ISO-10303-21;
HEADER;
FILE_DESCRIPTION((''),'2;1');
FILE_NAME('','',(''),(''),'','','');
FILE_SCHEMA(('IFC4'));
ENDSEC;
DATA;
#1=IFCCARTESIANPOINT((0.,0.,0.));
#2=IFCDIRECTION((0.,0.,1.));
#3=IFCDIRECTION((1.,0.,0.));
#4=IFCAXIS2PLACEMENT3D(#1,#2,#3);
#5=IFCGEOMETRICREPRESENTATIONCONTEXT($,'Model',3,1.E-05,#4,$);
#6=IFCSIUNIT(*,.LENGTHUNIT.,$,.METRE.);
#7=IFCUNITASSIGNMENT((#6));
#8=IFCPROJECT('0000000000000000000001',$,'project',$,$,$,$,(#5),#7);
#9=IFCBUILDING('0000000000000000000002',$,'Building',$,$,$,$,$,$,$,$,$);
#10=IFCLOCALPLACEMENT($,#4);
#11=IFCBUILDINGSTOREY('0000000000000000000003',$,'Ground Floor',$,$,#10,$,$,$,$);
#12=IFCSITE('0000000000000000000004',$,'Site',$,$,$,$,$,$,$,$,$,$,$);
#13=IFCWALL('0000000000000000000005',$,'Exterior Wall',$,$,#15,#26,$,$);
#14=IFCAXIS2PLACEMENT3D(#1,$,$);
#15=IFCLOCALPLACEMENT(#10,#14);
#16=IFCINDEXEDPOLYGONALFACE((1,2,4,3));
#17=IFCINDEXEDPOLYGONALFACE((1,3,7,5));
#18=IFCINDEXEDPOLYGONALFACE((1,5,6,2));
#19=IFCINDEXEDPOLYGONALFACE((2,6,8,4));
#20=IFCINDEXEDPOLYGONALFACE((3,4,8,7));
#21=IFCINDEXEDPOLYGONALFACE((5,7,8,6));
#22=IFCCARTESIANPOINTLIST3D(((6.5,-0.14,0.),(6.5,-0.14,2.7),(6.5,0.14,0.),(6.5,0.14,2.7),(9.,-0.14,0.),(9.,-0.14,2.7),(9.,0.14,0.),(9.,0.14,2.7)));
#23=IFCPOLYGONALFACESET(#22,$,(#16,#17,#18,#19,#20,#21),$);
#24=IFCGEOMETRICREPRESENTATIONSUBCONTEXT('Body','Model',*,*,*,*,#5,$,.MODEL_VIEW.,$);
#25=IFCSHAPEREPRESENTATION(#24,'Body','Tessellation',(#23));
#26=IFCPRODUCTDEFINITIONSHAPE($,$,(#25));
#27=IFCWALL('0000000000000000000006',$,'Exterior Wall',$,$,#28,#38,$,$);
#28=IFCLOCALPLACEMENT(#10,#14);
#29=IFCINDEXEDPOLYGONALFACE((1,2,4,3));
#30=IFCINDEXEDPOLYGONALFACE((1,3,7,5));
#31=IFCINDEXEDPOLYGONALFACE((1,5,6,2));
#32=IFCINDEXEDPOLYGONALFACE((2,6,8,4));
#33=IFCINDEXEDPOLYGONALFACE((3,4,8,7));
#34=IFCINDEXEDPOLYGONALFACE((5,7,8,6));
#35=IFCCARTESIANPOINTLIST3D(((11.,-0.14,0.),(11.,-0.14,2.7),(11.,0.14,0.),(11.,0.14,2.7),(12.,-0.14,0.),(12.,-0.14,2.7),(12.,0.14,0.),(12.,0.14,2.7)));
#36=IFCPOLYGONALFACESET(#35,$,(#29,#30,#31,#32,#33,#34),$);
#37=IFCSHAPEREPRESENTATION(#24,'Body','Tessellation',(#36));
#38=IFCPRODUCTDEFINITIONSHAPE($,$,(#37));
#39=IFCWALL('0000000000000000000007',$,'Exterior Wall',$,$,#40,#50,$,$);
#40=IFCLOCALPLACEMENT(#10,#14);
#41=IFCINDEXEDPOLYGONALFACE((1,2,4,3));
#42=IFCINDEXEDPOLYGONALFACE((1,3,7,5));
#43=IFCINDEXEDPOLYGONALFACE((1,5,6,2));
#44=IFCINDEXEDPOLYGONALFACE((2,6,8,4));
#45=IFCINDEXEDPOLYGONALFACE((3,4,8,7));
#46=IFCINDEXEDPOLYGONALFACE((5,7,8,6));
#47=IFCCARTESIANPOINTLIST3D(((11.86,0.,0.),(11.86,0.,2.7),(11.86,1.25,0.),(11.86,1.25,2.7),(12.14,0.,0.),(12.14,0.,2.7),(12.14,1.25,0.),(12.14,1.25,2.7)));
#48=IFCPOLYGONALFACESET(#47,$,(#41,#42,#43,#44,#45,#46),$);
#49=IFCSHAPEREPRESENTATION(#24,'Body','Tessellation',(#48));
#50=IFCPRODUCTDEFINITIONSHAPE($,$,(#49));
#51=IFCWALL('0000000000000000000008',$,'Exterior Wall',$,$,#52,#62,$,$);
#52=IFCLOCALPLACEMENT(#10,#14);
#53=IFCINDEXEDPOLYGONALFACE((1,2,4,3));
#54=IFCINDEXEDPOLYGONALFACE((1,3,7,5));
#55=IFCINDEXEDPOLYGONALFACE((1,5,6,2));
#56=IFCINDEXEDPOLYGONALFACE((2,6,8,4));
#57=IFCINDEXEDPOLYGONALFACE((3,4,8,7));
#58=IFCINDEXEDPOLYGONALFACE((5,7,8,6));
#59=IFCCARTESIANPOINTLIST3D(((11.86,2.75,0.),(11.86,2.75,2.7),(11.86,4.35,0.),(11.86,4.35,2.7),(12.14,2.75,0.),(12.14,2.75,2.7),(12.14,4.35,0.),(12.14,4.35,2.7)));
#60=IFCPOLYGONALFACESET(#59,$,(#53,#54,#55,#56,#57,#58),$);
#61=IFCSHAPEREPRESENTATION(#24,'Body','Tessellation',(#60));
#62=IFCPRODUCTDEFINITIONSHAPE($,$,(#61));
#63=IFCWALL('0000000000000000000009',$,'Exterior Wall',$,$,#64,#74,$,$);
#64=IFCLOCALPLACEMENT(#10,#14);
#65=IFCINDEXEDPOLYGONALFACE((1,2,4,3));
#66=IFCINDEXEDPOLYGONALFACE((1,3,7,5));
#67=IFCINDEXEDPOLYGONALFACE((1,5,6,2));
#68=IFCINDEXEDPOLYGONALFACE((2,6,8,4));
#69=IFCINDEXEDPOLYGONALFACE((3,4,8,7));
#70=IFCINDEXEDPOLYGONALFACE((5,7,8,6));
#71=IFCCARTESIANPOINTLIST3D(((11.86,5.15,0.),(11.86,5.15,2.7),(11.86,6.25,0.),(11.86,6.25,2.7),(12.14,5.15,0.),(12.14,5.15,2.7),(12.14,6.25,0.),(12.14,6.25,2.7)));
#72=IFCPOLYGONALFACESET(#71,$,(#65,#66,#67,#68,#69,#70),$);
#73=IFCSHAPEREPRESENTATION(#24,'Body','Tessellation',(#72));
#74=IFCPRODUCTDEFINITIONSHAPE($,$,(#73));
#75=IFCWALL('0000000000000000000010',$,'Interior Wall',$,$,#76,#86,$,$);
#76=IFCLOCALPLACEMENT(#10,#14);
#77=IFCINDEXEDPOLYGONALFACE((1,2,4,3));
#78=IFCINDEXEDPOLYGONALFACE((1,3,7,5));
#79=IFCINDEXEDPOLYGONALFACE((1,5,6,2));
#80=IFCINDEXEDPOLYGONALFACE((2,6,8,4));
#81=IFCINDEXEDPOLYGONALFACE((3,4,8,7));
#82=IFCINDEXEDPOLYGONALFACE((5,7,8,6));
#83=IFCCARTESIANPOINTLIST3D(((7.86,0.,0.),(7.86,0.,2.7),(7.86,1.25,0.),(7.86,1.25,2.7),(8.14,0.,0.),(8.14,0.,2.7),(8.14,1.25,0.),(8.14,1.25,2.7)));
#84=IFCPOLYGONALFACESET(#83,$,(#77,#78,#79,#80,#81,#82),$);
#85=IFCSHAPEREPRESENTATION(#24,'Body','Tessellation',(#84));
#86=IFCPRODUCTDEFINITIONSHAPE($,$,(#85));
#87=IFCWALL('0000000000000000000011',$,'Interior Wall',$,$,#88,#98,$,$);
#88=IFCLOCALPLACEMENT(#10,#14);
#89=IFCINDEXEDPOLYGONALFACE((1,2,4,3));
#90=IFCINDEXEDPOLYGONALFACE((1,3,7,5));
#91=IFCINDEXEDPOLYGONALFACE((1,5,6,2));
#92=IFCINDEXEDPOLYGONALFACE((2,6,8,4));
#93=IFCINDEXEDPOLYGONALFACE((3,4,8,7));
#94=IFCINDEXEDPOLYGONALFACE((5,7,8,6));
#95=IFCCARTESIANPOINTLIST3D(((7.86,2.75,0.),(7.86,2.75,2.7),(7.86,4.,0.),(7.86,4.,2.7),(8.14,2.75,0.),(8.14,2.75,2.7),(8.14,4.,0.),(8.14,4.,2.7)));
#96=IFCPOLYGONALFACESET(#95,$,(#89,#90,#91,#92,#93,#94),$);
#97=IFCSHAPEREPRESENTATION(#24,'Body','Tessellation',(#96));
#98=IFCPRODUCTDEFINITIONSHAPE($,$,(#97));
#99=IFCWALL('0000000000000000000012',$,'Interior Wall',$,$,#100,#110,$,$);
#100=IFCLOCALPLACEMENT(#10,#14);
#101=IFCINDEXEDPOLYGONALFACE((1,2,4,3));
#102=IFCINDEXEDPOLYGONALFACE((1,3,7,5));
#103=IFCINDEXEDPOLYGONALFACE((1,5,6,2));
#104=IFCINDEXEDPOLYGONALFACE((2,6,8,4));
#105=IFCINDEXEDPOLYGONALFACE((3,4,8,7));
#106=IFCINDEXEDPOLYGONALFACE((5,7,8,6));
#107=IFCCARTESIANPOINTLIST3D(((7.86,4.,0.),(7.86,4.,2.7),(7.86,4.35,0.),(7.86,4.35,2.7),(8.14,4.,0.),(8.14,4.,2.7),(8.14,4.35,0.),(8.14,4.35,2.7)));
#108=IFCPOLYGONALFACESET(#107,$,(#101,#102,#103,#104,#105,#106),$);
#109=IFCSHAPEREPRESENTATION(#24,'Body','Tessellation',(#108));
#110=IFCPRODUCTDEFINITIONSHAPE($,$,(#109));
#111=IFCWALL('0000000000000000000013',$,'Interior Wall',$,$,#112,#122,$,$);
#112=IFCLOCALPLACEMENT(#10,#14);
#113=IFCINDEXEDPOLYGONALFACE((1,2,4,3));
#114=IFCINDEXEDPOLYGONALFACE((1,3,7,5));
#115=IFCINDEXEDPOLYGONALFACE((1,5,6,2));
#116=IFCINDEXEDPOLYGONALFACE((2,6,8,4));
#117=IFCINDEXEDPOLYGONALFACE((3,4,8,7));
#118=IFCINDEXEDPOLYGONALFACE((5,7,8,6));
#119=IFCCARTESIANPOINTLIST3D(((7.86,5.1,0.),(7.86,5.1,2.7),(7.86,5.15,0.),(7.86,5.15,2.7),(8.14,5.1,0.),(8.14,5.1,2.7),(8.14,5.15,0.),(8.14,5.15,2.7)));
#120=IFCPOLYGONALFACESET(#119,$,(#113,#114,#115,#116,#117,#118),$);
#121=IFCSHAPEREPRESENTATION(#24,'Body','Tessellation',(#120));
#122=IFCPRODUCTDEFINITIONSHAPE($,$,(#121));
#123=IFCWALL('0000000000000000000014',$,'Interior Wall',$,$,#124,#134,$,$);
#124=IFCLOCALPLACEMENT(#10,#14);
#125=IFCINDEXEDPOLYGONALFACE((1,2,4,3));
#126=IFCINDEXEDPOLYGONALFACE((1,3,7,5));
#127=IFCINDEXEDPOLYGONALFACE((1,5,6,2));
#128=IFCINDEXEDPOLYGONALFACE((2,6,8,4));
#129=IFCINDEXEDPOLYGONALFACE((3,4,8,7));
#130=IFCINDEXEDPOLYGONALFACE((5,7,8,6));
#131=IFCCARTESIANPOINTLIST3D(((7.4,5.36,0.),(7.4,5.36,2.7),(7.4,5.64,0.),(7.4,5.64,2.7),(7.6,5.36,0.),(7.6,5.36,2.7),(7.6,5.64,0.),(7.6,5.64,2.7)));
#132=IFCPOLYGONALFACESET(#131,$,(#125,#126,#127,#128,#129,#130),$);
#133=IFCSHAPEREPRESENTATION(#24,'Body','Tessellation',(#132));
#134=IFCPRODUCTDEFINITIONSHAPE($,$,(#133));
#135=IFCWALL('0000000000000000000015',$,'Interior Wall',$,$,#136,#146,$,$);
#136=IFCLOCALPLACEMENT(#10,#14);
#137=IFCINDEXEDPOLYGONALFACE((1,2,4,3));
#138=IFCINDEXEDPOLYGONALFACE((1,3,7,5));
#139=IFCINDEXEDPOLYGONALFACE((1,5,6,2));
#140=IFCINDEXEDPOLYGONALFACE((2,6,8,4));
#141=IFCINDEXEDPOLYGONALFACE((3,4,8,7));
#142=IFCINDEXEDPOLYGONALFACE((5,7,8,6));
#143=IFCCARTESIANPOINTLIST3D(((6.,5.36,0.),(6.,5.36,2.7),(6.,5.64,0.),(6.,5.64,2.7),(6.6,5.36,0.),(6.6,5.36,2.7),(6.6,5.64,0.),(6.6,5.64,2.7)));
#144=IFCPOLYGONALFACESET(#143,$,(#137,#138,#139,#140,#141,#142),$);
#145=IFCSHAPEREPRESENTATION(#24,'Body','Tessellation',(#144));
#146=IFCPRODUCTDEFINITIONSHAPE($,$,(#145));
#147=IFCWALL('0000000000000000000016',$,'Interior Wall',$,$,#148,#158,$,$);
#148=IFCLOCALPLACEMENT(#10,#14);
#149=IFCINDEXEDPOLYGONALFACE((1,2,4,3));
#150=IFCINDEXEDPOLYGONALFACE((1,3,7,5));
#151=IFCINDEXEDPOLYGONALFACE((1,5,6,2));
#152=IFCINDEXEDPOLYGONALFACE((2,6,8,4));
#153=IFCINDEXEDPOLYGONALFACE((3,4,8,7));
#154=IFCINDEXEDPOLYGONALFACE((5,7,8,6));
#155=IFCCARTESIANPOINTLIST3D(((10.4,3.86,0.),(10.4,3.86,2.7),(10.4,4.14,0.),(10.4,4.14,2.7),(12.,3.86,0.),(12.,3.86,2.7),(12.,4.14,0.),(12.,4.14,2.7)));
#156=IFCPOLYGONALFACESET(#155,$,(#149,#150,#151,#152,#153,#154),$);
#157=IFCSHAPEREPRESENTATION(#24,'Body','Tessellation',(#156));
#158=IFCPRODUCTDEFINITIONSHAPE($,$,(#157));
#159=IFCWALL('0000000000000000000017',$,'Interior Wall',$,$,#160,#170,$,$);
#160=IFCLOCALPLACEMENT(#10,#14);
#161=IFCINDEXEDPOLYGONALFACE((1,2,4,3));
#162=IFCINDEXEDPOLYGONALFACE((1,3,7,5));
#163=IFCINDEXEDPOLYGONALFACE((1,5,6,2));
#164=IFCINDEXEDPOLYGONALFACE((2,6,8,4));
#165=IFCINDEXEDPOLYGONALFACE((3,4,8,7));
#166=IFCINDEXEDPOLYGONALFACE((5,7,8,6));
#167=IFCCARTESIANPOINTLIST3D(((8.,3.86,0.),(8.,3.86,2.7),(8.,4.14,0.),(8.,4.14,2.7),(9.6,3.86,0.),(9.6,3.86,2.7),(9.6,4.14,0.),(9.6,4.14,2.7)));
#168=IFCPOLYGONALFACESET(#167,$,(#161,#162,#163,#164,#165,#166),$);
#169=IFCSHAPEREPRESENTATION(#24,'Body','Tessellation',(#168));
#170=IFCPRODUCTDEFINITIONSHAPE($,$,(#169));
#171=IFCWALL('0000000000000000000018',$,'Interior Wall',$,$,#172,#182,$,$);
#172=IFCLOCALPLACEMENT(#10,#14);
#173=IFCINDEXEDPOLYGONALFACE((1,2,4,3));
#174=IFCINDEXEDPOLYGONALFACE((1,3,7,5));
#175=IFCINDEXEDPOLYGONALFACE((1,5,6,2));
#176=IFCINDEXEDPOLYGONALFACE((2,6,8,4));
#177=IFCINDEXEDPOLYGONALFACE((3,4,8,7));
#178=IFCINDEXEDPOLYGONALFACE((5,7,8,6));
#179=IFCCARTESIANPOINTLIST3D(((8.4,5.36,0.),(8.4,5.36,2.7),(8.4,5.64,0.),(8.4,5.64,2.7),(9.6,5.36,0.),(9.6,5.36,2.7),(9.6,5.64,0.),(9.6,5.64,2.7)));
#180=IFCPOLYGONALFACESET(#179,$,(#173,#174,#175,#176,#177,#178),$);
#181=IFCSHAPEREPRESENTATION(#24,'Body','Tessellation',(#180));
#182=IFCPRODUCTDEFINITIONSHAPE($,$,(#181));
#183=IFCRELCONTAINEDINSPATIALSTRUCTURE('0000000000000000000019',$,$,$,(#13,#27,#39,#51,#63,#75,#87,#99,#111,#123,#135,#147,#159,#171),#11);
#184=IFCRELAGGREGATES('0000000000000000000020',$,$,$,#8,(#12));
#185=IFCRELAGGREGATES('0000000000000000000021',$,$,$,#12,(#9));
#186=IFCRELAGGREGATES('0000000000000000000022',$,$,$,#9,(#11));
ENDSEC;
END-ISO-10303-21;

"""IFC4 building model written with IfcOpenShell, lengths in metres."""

from ifc_helpers import new_model, si_unit, frame, origin_with_axes, place, context, subcontext, project, spatial, indexed_curve, outline, extrude, element, save


model = new_model("IFC4")

# Units and contexts
model_context = context("Model", 3, precision=1e-05, world=origin_with_axes())
body_context = subcontext(model_context, "Body", "Model", "MODEL_VIEW")
ifc_project = project(units=[si_unit("LENGTHUNIT", "METRE")], contexts=[model_context])

# Site, building, storey
site = spatial("IfcSite", under=ifc_project, Name="Site")
building = spatial("IfcBuilding", under=site, Name="Building")
storey_placement = place(None, origin_with_axes())
storey = spatial("IfcBuildingStorey", under=building, at=storey_placement, Name="Ground Floor")

# Walls
wall_1_placement = place(storey_placement, frame((6.5, 0.0, 0.0), z_axis=(0.0, 0.0, 1.0), x_axis=(1.0, 0.0, 0.0)))
element("IfcWall", 1, at=wall_1_placement, inside=storey, Name="Exterior Wall", context=body_context, shape_type="SweptSolid", body=[
    extrude(outline(indexed_curve([(0.0, 0.0), (0.0, 0.28), (2.5, 0.28), (2.5, 0.0), (0.0, 0.0)], self_intersect=False)), frame((0.0, -0.14, 0.0), z_axis=(0.0, 0.0, 1.0), x_axis=(1.0, 0.0, 0.0)), (0.0, 0.0, 1.0), 2.7),
])
wall_2_placement = place(storey_placement, frame((11.0, 0.0, 0.0), z_axis=(0.0, 0.0, 1.0), x_axis=(1.0, 0.0, 0.0)))
element("IfcWall", 2, at=wall_2_placement, inside=storey, Name="Exterior Wall", context=body_context, shape_type="SweptSolid", body=[
    extrude(outline(indexed_curve([(0.0, 0.0), (0.0, 0.28), (1.0, 0.28), (1.0, 0.0), (0.0, 0.0)], self_intersect=False)), frame((0.0, -0.14, 0.0), z_axis=(0.0, 0.0, 1.0), x_axis=(1.0, 0.0, 0.0)), (0.0, 0.0, 1.0), 2.7),
])
wall_3_placement = place(storey_placement, frame((12.0, 0.0, 0.0), z_axis=(0.0, 0.0, 1.0), x_axis=(0.0, 1.0, 0.0)))
element("IfcWall", 3, at=wall_3_placement, inside=storey, Name="Exterior Wall", context=body_context, shape_type="SweptSolid", body=[
    extrude(outline(indexed_curve([(0.0, 0.0), (0.0, 0.28), (1.25, 0.28), (1.25, 0.0), (0.0, 0.0)], self_intersect=False)), frame((0.0, -0.14, 0.0), z_axis=(0.0, 0.0, 1.0), x_axis=(1.0, 0.0, 0.0)), (0.0, 0.0, 1.0), 2.7),
])
wall_4_placement = place(storey_placement, frame((12.0, 2.75, 0.0), z_axis=(0.0, 0.0, 1.0), x_axis=(0.0, 1.0, 0.0)))
element("IfcWall", 4, at=wall_4_placement, inside=storey, Name="Exterior Wall", context=body_context, shape_type="SweptSolid", body=[
    extrude(outline(indexed_curve([(0.0, 0.0), (0.0, 0.28), (1.6, 0.28), (1.6, 0.0), (0.0, 0.0)], self_intersect=False)), frame((0.0, -0.14, 0.0), z_axis=(0.0, 0.0, 1.0), x_axis=(1.0, 0.0, 0.0)), (0.0, 0.0, 1.0), 2.7),
])
wall_5_placement = place(storey_placement, frame((12.0, 5.15, 0.0), z_axis=(0.0, 0.0, 1.0), x_axis=(0.0, 1.0, 0.0)))
element("IfcWall", 5, at=wall_5_placement, inside=storey, Name="Exterior Wall", context=body_context, shape_type="SweptSolid", body=[
    extrude(outline(indexed_curve([(0.0, 0.0), (0.0, 0.28), (1.1, 0.28), (1.1, 0.0), (0.0, 0.0)], self_intersect=False)), frame((0.0, -0.14, 0.0), z_axis=(0.0, 0.0, 1.0), x_axis=(1.0, 0.0, 0.0)), (0.0, 0.0, 1.0), 2.7),
])
for number, where, z_axis, x_axis, name in (
    (6, (8.0, 0.0, 0.0), (0.0, 0.0, 1.0), (0.0, 1.0, 0.0), "Interior Wall"),
    (7, (8.0, 2.75, 0.0), (0.0, 0.0, 1.0), (0.0, 1.0, 0.0), "Interior Wall"),
):
    element("IfcWall", number, at=place(storey_placement, frame(where, z_axis=z_axis, x_axis=x_axis)), inside=storey, Name=name, context=body_context, shape_type="SweptSolid", body=[
        extrude(outline(indexed_curve([(0.0, 0.0), (0.0, 0.28), (1.25, 0.28), (1.25, 0.0), (0.0, 0.0)], self_intersect=False)), frame((0.0, -0.14, 0.0), z_axis=(0.0, 0.0, 1.0), x_axis=(1.0, 0.0, 0.0)), (0.0, 0.0, 1.0), 2.7),
    ])
wall_6_placement = place(storey_placement, frame((8.0, 4.0, 0.0), z_axis=(0.0, 0.0, 1.0), x_axis=(0.0, 1.0, 0.0)))
element("IfcWall", 8, at=wall_6_placement, inside=storey, Name="Interior Wall", context=body_context, shape_type="SweptSolid", body=[
    extrude(outline(indexed_curve([(0.0, 0.0), (0.0, 0.28), (0.35, 0.28), (0.35, 0.0), (0.0, 0.0)], self_intersect=False)), frame((0.0, -0.14, 0.0), z_axis=(0.0, 0.0, 1.0), x_axis=(1.0, 0.0, 0.0)), (0.0, 0.0, 1.0), 2.7),
])
wall_7_placement = place(storey_placement, frame((8.0, 5.15, 0.0), z_axis=(0.0, 0.0, 1.0), x_axis=(0.0, -1.0, 0.0)))
element("IfcWall", 9, at=wall_7_placement, inside=storey, Name="Interior Wall", context=body_context, shape_type="SweptSolid", body=[
    extrude(outline(indexed_curve([(0.0, 0.0), (0.0, 0.28), (0.05, 0.28), (0.05, 0.0), (0.0, 0.0)], self_intersect=False)), frame((0.0, -0.14, 0.0), z_axis=(0.0, 0.0, 1.0), x_axis=(1.0, 0.0, 0.0)), (0.0, 0.0, 1.0), 2.7),
])
wall_8_placement = place(storey_placement, frame((7.6, 5.5, 0.0), z_axis=(0.0, 0.0, 1.0), x_axis=(-1.0, 0.0, 0.0)))
element("IfcWall", 10, at=wall_8_placement, inside=storey, Name="Interior Wall", context=body_context, shape_type="SweptSolid", body=[
    extrude(outline(indexed_curve([(0.0, 0.0), (0.0, 0.28), (0.2, 0.28), (0.2, 0.0), (0.0, 0.0)], self_intersect=False)), frame((0.0, -0.14, 0.0), z_axis=(0.0, 0.0, 1.0), x_axis=(1.0, 0.0, 0.0)), (0.0, 0.0, 1.0), 2.7),
])
wall_9_placement = place(storey_placement, frame((6.6, 5.5, 0.0), z_axis=(0.0, 0.0, 1.0), x_axis=(-1.0, 0.0, 0.0)))
element("IfcWall", 11, at=wall_9_placement, inside=storey, Name="Interior Wall", context=body_context, shape_type="SweptSolid", body=[
    extrude(outline(indexed_curve([(0.0, 0.0), (0.0, 0.28), (0.6, 0.28), (0.6, 0.0), (0.0, 0.0)], self_intersect=False)), frame((0.0, -0.14, 0.0), z_axis=(0.0, 0.0, 1.0), x_axis=(1.0, 0.0, 0.0)), (0.0, 0.0, 1.0), 2.7),
])
for number, where, z_axis, x_axis, name in (
    (12, (12.0, 4.0, 0.0), (0.0, 0.0, 1.0), (-1.0, 0.0, 0.0), "Interior Wall"),
    (13, (9.6, 4.0, 0.0), (0.0, 0.0, 1.0), (-1.0, 0.0, 0.0), "Interior Wall"),
):
    element("IfcWall", number, at=place(storey_placement, frame(where, z_axis=z_axis, x_axis=x_axis)), inside=storey, Name=name, context=body_context, shape_type="SweptSolid", body=[
        extrude(outline(indexed_curve([(0.0, 0.0), (0.0, 0.28), (1.6, 0.28), (1.6, 0.0), (0.0, 0.0)], self_intersect=False)), frame((0.0, -0.14, 0.0), z_axis=(0.0, 0.0, 1.0), x_axis=(1.0, 0.0, 0.0)), (0.0, 0.0, 1.0), 2.7),
    ])
wall_10_placement = place(storey_placement, frame((9.6, 5.5, 0.0), z_axis=(0.0, 0.0, 1.0), x_axis=(-1.0, 0.0, 0.0)))
element("IfcWall", 14, at=wall_10_placement, inside=storey, Name="Interior Wall", context=body_context, shape_type="SweptSolid", body=[
    extrude(outline(indexed_curve([(0.0, 0.0), (0.0, 0.28), (1.2, 0.28), (1.2, 0.0), (0.0, 0.0)], self_intersect=False)), frame((0.0, -0.14, 0.0), z_axis=(0.0, 0.0, 1.0), x_axis=(1.0, 0.0, 0.0)), (0.0, 0.0, 1.0), 2.7),
])

save(model, "model.ifc")
